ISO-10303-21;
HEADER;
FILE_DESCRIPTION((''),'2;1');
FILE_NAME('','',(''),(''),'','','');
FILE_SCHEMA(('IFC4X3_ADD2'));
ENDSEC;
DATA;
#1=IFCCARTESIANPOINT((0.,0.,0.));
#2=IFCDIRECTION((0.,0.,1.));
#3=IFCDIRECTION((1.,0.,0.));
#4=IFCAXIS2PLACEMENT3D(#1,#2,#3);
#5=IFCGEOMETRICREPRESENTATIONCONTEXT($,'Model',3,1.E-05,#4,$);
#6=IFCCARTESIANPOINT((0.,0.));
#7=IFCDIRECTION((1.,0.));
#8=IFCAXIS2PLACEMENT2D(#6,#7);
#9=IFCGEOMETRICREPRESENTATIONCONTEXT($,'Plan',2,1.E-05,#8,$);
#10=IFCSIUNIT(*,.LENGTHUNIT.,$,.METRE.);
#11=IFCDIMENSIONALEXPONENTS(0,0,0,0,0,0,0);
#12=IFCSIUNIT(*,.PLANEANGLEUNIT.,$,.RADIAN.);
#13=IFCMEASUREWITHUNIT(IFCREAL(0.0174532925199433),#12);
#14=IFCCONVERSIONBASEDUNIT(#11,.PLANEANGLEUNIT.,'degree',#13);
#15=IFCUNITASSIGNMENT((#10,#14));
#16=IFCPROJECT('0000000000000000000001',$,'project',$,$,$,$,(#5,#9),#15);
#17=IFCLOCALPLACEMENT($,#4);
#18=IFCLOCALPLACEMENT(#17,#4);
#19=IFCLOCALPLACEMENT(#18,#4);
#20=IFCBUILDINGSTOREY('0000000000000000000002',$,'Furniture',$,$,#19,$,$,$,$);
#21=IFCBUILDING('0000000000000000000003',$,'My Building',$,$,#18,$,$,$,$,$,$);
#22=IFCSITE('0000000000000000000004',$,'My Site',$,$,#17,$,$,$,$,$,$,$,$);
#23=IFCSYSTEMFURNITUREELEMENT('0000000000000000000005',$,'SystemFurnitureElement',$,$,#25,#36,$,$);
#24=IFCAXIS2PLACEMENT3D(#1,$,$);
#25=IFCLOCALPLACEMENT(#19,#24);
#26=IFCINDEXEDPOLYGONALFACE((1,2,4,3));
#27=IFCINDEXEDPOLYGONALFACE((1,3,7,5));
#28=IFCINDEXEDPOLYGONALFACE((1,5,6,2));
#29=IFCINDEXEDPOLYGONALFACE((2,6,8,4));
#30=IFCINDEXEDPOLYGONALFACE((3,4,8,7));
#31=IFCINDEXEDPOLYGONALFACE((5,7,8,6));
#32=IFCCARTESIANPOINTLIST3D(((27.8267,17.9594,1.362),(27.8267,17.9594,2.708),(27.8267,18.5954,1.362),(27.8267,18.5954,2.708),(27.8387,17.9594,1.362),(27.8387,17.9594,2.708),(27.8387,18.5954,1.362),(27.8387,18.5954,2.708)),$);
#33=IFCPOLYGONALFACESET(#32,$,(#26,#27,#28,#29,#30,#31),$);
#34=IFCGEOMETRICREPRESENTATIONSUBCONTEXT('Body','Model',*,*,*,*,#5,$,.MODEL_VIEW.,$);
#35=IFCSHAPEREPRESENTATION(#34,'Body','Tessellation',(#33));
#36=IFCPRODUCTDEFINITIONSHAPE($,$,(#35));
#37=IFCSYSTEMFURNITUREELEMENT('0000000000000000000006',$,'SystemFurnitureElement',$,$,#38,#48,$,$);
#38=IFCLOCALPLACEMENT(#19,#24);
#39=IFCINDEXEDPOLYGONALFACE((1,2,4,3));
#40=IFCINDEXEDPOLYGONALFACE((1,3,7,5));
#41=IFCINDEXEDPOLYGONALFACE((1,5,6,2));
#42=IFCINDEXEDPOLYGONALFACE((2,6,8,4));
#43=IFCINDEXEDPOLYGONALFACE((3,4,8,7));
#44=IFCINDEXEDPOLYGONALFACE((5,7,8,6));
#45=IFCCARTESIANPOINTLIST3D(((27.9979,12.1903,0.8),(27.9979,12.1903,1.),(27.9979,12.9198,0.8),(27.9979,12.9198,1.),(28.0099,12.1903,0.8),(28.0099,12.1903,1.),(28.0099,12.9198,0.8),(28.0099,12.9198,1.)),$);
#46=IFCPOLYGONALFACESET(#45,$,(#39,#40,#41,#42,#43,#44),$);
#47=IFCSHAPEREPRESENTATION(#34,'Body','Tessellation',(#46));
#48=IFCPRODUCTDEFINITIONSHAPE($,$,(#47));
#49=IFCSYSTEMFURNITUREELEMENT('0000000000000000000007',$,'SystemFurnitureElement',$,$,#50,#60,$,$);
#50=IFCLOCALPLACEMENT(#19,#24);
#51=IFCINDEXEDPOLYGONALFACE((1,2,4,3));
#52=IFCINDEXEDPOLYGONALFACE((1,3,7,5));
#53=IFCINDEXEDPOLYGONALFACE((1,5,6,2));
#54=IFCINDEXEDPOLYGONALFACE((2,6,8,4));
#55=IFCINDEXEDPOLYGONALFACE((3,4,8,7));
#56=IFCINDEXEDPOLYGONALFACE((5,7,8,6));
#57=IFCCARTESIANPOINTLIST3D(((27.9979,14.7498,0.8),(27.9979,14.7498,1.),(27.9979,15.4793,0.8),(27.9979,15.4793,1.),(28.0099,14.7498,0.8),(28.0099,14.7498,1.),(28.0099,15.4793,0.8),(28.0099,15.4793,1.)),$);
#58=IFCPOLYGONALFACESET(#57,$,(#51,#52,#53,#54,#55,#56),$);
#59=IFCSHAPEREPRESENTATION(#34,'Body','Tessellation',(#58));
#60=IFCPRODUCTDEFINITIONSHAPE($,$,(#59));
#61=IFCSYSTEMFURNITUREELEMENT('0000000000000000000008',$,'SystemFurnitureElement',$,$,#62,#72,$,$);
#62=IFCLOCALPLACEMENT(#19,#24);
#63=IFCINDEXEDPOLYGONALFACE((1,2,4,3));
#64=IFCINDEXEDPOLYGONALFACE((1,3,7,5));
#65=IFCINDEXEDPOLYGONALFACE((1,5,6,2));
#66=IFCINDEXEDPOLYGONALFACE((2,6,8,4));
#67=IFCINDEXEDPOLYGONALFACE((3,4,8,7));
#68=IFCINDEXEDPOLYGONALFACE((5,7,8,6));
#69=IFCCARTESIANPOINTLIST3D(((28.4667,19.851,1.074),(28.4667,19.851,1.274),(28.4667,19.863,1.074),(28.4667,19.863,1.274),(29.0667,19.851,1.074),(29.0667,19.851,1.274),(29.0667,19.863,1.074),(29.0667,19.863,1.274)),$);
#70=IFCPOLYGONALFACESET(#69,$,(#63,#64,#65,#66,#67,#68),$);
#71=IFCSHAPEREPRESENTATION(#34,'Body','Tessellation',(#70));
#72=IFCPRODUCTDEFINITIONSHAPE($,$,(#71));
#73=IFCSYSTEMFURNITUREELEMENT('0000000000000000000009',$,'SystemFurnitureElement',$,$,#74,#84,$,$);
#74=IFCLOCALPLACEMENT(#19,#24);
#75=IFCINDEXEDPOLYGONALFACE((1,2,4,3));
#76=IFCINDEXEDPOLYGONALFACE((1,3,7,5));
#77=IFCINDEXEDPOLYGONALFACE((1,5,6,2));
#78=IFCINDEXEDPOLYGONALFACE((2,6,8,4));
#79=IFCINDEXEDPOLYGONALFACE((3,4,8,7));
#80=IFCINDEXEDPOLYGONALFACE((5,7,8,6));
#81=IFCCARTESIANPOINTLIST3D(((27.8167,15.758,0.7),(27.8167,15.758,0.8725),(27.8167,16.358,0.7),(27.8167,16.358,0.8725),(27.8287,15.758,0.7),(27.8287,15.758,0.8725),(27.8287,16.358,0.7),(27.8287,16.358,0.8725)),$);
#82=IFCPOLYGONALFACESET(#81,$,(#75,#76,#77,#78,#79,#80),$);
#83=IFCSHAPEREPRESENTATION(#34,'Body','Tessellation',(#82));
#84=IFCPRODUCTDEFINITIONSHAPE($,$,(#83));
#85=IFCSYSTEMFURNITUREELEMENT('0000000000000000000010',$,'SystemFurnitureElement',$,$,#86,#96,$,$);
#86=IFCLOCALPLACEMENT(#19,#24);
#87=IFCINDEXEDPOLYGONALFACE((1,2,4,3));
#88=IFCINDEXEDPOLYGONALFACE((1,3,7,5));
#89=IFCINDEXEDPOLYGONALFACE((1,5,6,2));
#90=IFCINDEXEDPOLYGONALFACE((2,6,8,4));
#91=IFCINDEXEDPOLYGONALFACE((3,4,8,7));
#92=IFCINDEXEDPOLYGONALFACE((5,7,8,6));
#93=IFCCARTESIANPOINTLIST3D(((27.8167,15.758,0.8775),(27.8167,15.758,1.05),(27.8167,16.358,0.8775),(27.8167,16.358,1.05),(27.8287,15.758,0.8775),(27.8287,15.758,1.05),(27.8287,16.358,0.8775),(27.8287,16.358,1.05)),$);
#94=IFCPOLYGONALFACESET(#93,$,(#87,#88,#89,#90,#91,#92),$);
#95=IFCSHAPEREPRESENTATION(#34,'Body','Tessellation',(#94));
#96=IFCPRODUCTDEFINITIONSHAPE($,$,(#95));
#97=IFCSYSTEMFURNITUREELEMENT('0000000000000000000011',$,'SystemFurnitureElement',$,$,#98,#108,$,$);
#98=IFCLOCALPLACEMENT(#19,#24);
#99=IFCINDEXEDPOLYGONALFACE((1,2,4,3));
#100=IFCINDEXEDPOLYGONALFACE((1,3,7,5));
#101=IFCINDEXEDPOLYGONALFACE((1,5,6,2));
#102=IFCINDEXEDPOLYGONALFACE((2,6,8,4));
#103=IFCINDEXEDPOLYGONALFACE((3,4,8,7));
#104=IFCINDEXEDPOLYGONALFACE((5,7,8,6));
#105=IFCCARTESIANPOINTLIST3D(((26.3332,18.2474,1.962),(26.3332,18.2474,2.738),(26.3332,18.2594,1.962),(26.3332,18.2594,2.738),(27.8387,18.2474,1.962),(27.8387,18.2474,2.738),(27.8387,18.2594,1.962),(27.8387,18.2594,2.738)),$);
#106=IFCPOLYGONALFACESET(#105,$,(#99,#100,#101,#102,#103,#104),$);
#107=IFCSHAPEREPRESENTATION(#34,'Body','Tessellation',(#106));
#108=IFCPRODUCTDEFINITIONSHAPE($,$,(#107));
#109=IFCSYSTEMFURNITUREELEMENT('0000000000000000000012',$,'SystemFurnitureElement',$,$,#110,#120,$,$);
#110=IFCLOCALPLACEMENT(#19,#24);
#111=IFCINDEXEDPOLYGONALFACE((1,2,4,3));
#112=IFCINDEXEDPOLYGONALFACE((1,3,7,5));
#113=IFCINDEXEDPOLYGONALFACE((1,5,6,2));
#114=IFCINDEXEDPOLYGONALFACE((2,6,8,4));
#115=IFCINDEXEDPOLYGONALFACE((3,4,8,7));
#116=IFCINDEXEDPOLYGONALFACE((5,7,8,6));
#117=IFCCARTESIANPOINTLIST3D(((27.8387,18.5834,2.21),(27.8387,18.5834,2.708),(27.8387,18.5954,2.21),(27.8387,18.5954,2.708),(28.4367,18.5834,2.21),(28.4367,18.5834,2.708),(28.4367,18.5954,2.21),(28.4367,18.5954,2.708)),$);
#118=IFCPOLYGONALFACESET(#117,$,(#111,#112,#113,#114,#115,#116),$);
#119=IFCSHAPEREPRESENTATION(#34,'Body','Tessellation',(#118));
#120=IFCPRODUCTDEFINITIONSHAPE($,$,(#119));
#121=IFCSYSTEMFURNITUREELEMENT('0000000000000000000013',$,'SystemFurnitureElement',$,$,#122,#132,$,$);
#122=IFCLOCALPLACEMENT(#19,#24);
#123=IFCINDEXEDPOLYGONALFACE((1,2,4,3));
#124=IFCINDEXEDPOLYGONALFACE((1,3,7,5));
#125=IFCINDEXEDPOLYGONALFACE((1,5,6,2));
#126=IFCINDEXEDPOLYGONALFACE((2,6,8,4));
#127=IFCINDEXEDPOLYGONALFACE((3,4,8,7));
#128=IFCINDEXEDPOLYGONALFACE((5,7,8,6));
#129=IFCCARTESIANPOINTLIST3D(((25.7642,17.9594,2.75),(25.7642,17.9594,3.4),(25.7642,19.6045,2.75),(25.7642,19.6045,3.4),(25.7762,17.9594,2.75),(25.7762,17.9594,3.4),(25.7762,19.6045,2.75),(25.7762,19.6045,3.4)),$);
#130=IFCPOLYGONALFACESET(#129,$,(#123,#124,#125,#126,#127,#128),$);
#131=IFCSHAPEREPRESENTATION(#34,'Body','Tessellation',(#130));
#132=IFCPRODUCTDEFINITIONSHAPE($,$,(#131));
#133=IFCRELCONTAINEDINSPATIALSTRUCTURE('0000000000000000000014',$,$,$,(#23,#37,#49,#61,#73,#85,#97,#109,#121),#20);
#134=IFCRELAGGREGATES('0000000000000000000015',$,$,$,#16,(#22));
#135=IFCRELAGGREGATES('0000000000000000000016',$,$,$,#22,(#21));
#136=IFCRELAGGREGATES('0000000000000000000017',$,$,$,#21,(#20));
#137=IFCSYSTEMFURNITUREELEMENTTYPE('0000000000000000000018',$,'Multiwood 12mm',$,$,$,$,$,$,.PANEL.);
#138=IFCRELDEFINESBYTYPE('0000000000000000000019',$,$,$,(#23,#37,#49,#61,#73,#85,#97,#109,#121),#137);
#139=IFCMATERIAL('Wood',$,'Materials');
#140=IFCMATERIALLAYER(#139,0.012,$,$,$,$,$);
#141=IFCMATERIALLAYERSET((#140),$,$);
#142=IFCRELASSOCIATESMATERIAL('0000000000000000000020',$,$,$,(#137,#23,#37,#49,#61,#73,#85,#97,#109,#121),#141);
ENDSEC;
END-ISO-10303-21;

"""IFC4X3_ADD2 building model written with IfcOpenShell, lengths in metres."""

from ifc_helpers import new_model, entity, si_unit, converted_unit, frame, origin_with_axes, origin_2d_with_axis, place, context, subcontext, project, spatial, line, indexed_curve, outline, extrude, material, layer, layer_set, layer_usage, type_object, element, save


model = new_model("IFC4X3_ADD2")

# Units and contexts
model_context = context("Model", 3, precision=1e-05, world=origin_with_axes())
plan_context = context("Plan", 2, precision=1e-05, world=origin_2d_with_axis())
body_context = subcontext(model_context, "Body", "Model", "MODEL_VIEW")
ifc_project = project(units=[si_unit("LENGTHUNIT", "METRE"), converted_unit("PLANEANGLEUNIT", "degree", entity("IfcReal", 0.0174532925199433), si_unit("PLANEANGLEUNIT", "RADIAN"), dimensions=[0, 0, 0, 0, 0, 0, 0])], contexts=[model_context, plan_context])

# Site, building, storey
site_placement = place(None, origin_with_axes())
site = spatial("IfcSite", under=ifc_project, at=site_placement, Name="My Site")
building_placement = place(site_placement, origin_with_axes())
building = spatial("IfcBuilding", under=site, at=building_placement, Name="My Building")
storey_placement = place(building_placement, origin_with_axes())
storey = spatial("IfcBuildingStorey", under=building, at=storey_placement, Name="Furniture")

# System furniture elements
ifc_material_1 = material(Name="Wood", Category="Materials")
ifc_layer_1 = layer(ifc_material_1, 0.012)
ifc_layer_set_1 = layer_set([ifc_layer_1])
ifc_layer_usage_1 = layer_usage(ifc_layer_set_1, "AXIS2", "POSITIVE", 0.0)
system_furniture_element_type_1 = type_object("IfcSystemFurnitureElementType", Name="Multiwood 12mm", PredefinedType="PANEL", material=ifc_layer_set_1)
system_furniture_element_1_placement = place(storey_placement, frame((27.8267, 18.5954, 1.362), z_axis=(0.0, 0.0, 1.0), x_axis=(-0.000001, -1.0, 0.0)))
element("IfcSystemFurnitureElement", 1, at=system_furniture_element_1_placement, inside=storey, type_object=system_furniture_element_type_1, material=ifc_layer_usage_1, Name="SystemFurnitureElement", context=body_context, shape_type="SweptSolid", body=[
    extrude(outline(indexed_curve([(0.0, 0.0), (0.0, 0.012), (0.636, 0.012), (0.636, 0.0)], segments=[line(1, 2, 3, 4, 1)])), origin_with_axes(), (0.0, 0.0, 1.0), 1.346),
])
ifc_layer_usage_2 = layer_usage(ifc_layer_set_1, "AXIS2", "POSITIVE", 0.0)
system_furniture_element_2_placement = place(storey_placement, frame((27.9979, 12.9198, 0.8), z_axis=(0.0, 0.0, 1.0), x_axis=(0.0, -1.0, 0.0)))
element("IfcSystemFurnitureElement", 2, at=system_furniture_element_2_placement, inside=storey, type_object=system_furniture_element_type_1, material=ifc_layer_usage_2, Name="SystemFurnitureElement", context=body_context, shape_type="SweptSolid", body=[
    extrude(outline(indexed_curve([(0.0, 0.0), (0.0, 0.012), (0.7295, 0.012), (0.7295, 0.0)], segments=[line(1, 2, 3, 4, 1)])), origin_with_axes(), (0.0, 0.0, 1.0), 0.2),
])
ifc_layer_usage_3 = layer_usage(ifc_layer_set_1, "AXIS2", "POSITIVE", 0.0)
system_furniture_element_3_placement = place(storey_placement, frame((27.9979, 15.4793, 0.8), z_axis=(0.0, 0.0, 1.0), x_axis=(0.0, -1.0, 0.0)))
element("IfcSystemFurnitureElement", 3, at=system_furniture_element_3_placement, inside=storey, type_object=system_furniture_element_type_1, material=ifc_layer_usage_3, Name="SystemFurnitureElement", context=body_context, shape_type="SweptSolid", body=[
    extrude(outline(indexed_curve([(0.0, 0.0), (0.0, 0.012), (0.7295, 0.012), (0.7295, 0.0)], segments=[line(1, 2, 3, 4, 1)])), origin_with_axes(), (0.0, 0.0, 1.0), 0.2),
])
ifc_layer_usage_4 = layer_usage(ifc_layer_set_1, "AXIS2", "POSITIVE", 0.0)
system_furniture_element_4_placement = place(storey_placement, frame((29.0667, 19.863, 1.074), z_axis=(0.0, 0.0, 1.0), x_axis=(-1.0, 0.000001, 0.0)))
element("IfcSystemFurnitureElement", 4, at=system_furniture_element_4_placement, inside=storey, type_object=system_furniture_element_type_1, material=ifc_layer_usage_4, Name="SystemFurnitureElement", context=body_context, shape_type="SweptSolid", body=[
    extrude(outline(indexed_curve([(0.0, 0.0), (0.0, 0.012), (0.6, 0.012), (0.6, 0.0)], segments=[line(1, 2, 3, 4, 1)])), origin_with_axes(), (0.0, 0.0, 1.0), 0.2),
])
ifc_layer_usage_5 = layer_usage(ifc_layer_set_1, "AXIS2", "POSITIVE", 0.0)
system_furniture_element_5_placement = place(storey_placement, frame((27.8167, 16.358, 0.7), z_axis=(0.0, 0.0, 1.0), x_axis=(-0.000001, -1.0, 0.0)))
element("IfcSystemFurnitureElement", 5, at=system_furniture_element_5_placement, inside=storey, type_object=system_furniture_element_type_1, material=ifc_layer_usage_5, Name="SystemFurnitureElement", context=body_context, shape_type="SweptSolid", body=[
    extrude(outline(indexed_curve([(0.0, 0.0), (0.0, 0.012), (0.6, 0.012), (0.6, 0.0)], segments=[line(1, 2, 3, 4, 1)])), origin_with_axes(), (0.0, 0.0, 1.0), 0.1725),
])
ifc_layer_usage_6 = layer_usage(ifc_layer_set_1, "AXIS2", "POSITIVE", 0.0)
system_furniture_element_6_placement = place(storey_placement, frame((27.8167, 16.358, 0.8775), z_axis=(0.0, 0.0, 1.0), x_axis=(-0.000001, -1.0, 0.0)))
element("IfcSystemFurnitureElement", 6, at=system_furniture_element_6_placement, inside=storey, type_object=system_furniture_element_type_1, material=ifc_layer_usage_6, Name="SystemFurnitureElement", context=body_context, shape_type="SweptSolid", body=[
    extrude(outline(indexed_curve([(0.0, 0.0), (0.0, 0.012), (0.6, 0.012), (0.6, 0.0)], segments=[line(1, 2, 3, 4, 1)])), origin_with_axes(), (0.0, 0.0, 1.0), 0.1725),
])
ifc_layer_usage_7 = layer_usage(ifc_layer_set_1, "AXIS2", "POSITIVE", 0.0)
system_furniture_element_7_placement = place(storey_placement, frame((27.8387, 18.2594, 1.962), z_axis=(0.0, 0.0, 1.0), x_axis=(-1.0, 0.0, 0.0)))
element("IfcSystemFurnitureElement", 7, at=system_furniture_element_7_placement, inside=storey, type_object=system_furniture_element_type_1, material=ifc_layer_usage_7, Name="SystemFurnitureElement", context=body_context, shape_type="SweptSolid", body=[
    extrude(outline(indexed_curve([(0.0, 0.0), (0.0, 0.012), (1.5054, 0.012), (1.5054, 0.0)], segments=[line(1, 2, 3, 4, 1)])), origin_with_axes(), (0.0, 0.0, 1.0), 0.776),
])
ifc_layer_usage_8 = layer_usage(ifc_layer_set_1, "AXIS2", "POSITIVE", 0.0)
system_furniture_element_8_placement = place(storey_placement, frame((28.4367, 18.5954, 2.21), z_axis=(0.0, 0.0, 1.0), x_axis=(-1.0, 0.0, 0.0)))
element("IfcSystemFurnitureElement", 8, at=system_furniture_element_8_placement, inside=storey, type_object=system_furniture_element_type_1, material=ifc_layer_usage_8, Name="SystemFurnitureElement", context=body_context, shape_type="SweptSolid", body=[
    extrude(outline(indexed_curve([(0.0, 0.0), (0.0, 0.012), (0.598, 0.012), (0.598, 0.0)], segments=[line(1, 2, 3, 4, 1)])), origin_with_axes(), (0.0, 0.0, 1.0), 0.498),
])
ifc_layer_usage_9 = layer_usage(ifc_layer_set_1, "AXIS2", "POSITIVE", 0.0)
system_furniture_element_9_placement = place(storey_placement, frame((25.7762, 17.9594, 2.75), z_axis=(0.0, 0.0, 1.0), x_axis=(0.000001, 1.0, 0.0)))
element("IfcSystemFurnitureElement", 9, at=system_furniture_element_9_placement, inside=storey, type_object=system_furniture_element_type_1, material=ifc_layer_usage_9, Name="SystemFurnitureElement", context=body_context, shape_type="SweptSolid", body=[
    extrude(outline(indexed_curve([(0.0, 0.0), (0.0, 0.012), (1.6452, 0.012), (1.6452, 0.0)], segments=[line(1, 2, 3, 4, 1)])), origin_with_axes(), (0.0, 0.0, 1.0), 0.65),
])

save(model, "model.ifc")
